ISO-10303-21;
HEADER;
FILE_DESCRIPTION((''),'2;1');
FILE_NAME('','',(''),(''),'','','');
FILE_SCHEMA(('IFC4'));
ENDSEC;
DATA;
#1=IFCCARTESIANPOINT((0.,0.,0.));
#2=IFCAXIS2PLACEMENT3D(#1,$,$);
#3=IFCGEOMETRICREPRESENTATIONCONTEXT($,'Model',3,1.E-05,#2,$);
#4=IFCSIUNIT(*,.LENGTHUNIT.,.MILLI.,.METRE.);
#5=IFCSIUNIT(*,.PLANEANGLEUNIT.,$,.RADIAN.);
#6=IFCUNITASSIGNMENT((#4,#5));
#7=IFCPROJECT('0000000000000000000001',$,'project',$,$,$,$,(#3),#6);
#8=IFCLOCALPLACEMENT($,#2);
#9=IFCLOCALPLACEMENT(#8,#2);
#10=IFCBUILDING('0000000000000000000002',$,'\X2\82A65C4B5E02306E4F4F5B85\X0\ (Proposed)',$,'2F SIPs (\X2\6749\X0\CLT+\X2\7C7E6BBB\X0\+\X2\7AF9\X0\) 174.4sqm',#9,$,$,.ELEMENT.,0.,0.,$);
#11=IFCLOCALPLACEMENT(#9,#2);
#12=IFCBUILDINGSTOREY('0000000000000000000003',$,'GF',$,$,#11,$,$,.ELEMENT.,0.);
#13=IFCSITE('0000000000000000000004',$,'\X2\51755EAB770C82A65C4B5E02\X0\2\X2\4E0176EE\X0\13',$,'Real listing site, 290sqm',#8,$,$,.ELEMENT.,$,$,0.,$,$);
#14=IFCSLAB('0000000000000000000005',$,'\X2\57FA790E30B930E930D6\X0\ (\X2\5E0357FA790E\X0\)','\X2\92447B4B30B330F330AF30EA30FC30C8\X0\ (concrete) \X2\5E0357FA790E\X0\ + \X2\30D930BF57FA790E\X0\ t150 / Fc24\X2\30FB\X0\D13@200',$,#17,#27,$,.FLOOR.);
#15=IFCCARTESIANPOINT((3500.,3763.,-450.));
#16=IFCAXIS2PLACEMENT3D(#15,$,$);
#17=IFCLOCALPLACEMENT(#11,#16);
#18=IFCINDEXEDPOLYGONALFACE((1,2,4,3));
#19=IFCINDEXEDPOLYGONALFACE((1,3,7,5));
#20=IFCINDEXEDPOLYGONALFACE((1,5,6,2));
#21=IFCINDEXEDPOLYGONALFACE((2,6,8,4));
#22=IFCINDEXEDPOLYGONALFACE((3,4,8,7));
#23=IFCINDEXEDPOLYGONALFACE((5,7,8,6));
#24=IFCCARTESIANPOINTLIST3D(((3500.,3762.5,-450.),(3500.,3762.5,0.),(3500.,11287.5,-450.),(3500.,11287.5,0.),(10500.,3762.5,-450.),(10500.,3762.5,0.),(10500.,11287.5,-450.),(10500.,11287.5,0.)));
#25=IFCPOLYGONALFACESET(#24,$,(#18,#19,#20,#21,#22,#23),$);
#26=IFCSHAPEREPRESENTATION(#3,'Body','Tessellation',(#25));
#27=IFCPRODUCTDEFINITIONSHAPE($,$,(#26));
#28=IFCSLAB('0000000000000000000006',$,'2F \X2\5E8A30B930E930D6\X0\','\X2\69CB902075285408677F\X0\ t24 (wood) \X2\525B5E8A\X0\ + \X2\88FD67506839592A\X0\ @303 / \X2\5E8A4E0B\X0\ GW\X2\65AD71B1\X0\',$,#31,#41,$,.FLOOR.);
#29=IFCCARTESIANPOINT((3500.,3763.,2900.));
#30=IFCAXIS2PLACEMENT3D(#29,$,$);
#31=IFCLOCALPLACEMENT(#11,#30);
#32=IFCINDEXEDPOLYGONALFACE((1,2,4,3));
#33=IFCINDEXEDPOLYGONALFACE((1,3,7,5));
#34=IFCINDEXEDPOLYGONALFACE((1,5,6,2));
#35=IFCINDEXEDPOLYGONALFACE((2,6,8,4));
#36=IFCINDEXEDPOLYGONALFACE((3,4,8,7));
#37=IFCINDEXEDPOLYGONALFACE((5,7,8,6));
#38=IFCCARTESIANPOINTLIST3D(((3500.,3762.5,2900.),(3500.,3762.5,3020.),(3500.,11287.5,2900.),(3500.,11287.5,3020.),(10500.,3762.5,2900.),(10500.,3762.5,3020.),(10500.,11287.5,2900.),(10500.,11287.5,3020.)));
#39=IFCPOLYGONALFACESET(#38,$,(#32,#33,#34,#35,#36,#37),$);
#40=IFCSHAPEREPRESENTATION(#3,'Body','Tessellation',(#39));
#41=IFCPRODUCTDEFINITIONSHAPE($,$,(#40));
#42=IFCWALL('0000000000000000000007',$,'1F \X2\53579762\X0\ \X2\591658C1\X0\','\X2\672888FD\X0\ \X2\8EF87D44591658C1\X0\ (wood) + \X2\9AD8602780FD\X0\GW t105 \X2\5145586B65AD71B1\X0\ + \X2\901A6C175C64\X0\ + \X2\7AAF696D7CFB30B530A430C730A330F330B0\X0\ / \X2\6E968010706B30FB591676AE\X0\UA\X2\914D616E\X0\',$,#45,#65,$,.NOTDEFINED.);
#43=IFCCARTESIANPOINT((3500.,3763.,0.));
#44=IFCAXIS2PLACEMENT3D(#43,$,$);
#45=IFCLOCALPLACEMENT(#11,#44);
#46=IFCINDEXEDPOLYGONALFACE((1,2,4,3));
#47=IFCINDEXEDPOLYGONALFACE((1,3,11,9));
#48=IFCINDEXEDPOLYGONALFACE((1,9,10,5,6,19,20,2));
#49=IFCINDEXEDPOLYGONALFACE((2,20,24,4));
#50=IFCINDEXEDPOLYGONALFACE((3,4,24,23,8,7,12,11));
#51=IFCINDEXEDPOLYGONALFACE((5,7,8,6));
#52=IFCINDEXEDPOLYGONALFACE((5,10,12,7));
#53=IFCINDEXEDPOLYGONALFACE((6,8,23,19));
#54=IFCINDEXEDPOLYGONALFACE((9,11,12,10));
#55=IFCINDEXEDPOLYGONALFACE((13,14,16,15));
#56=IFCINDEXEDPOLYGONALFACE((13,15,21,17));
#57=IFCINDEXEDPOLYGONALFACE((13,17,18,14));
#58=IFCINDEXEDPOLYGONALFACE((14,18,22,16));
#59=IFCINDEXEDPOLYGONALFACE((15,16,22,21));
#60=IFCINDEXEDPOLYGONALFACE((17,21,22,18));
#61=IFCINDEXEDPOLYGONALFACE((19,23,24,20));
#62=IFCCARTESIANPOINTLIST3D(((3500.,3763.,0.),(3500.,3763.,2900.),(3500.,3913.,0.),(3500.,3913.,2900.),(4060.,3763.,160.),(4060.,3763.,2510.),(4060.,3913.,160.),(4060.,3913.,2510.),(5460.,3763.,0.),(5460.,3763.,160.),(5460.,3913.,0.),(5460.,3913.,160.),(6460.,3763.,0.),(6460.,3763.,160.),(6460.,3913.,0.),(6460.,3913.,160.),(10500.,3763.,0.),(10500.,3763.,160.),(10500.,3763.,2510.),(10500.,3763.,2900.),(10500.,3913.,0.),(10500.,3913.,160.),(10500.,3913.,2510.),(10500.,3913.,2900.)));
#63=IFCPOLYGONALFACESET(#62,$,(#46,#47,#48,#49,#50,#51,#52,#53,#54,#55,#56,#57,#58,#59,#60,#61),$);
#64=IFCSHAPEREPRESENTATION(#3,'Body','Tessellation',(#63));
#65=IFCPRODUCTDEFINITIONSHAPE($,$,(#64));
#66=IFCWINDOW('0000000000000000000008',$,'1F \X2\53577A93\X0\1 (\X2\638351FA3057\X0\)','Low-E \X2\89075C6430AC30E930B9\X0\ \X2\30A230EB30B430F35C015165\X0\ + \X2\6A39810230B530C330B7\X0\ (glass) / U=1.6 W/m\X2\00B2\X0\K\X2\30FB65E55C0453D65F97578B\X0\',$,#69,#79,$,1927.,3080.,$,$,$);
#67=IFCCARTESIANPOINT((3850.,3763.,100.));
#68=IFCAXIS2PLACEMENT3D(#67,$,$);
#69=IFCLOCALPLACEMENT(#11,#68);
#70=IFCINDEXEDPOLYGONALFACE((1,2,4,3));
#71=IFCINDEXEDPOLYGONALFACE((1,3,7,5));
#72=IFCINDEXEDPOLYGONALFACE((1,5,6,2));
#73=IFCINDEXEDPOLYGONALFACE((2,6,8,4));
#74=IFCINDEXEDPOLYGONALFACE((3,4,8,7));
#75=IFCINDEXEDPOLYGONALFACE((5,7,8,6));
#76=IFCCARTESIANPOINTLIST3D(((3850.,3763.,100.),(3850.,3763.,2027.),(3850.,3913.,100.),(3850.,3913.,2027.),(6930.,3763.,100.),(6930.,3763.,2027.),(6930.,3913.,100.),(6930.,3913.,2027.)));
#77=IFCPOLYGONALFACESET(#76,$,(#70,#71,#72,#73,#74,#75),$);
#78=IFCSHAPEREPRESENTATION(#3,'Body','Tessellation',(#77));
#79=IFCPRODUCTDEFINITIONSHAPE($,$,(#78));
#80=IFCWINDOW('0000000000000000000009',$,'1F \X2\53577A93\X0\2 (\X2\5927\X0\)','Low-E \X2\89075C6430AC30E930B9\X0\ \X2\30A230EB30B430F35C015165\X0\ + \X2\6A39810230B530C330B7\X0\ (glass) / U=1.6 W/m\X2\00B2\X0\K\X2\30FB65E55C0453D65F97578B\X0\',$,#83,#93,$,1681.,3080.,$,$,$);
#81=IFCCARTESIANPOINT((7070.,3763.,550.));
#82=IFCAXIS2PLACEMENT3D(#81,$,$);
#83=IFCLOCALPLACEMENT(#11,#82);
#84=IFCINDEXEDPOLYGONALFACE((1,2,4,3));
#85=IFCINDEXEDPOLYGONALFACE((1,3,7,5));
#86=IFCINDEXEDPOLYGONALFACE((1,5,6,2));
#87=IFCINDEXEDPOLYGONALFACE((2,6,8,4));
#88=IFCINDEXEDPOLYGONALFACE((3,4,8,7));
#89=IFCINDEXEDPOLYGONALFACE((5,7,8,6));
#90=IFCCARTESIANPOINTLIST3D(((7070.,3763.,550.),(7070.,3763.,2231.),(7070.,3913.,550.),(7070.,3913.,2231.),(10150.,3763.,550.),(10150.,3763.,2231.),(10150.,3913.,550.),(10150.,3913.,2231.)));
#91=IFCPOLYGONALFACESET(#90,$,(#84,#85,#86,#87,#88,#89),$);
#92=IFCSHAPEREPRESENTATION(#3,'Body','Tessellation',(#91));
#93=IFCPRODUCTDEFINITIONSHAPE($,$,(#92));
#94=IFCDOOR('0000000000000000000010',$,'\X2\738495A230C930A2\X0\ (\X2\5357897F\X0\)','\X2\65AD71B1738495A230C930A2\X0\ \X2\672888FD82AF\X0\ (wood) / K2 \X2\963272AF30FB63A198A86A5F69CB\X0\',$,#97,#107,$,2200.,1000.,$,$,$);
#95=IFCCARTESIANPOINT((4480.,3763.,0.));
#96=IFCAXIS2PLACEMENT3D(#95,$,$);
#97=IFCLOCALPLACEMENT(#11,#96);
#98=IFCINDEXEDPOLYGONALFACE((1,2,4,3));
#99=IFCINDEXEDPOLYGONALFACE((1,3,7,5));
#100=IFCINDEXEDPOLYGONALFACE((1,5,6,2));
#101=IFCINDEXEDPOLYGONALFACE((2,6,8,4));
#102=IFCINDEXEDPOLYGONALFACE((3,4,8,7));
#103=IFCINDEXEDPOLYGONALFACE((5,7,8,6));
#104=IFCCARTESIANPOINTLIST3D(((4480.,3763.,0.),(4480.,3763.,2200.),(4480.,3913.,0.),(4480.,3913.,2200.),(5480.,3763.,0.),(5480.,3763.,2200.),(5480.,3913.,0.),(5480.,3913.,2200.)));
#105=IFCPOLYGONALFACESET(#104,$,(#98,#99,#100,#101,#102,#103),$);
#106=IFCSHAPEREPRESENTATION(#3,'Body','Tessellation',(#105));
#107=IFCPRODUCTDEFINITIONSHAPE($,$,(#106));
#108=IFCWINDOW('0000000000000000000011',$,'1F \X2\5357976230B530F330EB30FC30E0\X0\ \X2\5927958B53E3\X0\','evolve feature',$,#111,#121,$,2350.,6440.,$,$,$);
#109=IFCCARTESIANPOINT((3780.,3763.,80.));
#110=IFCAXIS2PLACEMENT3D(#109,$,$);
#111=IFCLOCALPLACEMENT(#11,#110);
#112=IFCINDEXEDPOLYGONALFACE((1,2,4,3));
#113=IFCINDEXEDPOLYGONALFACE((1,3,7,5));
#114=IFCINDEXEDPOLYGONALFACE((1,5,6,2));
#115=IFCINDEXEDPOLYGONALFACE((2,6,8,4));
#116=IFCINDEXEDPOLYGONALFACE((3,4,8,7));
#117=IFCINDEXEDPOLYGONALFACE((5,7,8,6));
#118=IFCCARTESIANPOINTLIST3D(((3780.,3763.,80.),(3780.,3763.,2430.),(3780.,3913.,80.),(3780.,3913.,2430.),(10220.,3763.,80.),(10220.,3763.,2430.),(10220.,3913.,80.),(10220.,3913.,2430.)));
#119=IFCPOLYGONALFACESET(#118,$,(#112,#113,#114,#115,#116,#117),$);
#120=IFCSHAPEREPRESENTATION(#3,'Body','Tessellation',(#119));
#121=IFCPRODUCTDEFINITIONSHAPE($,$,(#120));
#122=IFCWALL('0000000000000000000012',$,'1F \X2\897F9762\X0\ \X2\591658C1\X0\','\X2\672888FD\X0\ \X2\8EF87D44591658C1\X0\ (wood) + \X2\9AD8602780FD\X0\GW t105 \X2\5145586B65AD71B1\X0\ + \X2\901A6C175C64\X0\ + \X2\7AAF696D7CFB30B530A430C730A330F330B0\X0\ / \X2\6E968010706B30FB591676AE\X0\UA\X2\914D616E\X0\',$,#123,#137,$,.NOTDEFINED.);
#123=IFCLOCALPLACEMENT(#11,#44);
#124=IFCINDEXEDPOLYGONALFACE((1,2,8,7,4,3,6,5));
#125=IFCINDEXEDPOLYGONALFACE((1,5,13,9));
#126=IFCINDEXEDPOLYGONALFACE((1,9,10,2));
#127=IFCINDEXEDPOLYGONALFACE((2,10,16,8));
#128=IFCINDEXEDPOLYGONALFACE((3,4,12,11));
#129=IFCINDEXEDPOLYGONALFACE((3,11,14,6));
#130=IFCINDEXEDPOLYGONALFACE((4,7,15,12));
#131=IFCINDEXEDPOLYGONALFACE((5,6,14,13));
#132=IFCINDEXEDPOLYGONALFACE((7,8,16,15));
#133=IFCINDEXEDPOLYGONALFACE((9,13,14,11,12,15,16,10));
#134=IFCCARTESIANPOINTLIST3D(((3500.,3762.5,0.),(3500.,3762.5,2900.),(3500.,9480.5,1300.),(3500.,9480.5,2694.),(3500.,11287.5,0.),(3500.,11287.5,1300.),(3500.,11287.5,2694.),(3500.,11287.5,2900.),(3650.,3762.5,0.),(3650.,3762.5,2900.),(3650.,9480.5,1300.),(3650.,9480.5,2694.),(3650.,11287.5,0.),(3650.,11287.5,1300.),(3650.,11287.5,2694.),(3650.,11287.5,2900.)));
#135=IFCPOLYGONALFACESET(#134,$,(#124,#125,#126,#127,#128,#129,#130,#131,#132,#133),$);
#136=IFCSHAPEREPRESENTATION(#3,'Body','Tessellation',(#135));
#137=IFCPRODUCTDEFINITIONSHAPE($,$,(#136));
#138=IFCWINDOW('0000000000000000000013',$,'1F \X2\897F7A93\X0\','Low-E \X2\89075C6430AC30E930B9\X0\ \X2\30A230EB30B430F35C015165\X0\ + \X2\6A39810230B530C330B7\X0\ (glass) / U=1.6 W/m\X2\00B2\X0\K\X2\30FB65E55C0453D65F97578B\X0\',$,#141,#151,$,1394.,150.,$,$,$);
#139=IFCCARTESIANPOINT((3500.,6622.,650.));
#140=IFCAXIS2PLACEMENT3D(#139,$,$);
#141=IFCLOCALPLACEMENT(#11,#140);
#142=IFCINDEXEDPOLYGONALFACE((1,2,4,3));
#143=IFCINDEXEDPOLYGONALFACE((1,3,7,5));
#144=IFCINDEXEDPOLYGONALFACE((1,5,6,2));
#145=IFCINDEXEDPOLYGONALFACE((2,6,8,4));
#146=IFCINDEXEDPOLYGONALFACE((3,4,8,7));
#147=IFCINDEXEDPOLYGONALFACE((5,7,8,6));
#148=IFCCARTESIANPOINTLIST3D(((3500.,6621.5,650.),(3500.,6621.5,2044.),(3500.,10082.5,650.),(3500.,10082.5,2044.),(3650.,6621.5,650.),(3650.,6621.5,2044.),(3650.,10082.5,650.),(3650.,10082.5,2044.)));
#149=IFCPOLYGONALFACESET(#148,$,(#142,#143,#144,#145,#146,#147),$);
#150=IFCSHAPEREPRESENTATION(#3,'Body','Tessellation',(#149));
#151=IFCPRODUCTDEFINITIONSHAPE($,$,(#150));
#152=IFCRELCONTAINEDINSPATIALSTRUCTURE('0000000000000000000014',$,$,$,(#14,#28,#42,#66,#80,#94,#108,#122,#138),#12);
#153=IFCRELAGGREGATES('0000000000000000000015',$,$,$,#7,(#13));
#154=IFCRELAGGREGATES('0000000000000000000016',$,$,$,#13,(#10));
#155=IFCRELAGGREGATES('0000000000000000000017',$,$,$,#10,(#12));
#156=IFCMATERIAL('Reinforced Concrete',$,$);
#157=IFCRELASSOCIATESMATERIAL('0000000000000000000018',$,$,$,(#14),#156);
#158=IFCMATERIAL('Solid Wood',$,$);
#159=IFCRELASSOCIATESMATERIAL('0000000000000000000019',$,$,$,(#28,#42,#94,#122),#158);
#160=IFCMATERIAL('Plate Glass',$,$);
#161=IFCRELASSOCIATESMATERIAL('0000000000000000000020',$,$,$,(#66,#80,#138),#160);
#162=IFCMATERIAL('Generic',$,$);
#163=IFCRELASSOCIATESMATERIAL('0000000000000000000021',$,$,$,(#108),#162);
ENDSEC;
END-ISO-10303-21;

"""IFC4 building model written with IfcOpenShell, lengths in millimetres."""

from ifc_helpers import new_model, si_unit, frame, frame_2d, origin, place, context, project, spatial, rectangle, extrude, material, element, fill, save


model = new_model("IFC4")

# Units and contexts
model_context = context("Model", 3, precision=1e-05, world=origin())
ifc_project = project(units=[si_unit("LENGTHUNIT", "METRE", prefix="MILLI"), si_unit("PLANEANGLEUNIT", "RADIAN")], contexts=[model_context])

# Site, building, storey
site_placement = place(None, origin())
site = spatial("IfcSite", under=ifc_project, at=site_placement, Name="兵庫県芦屋市2丁目13", ObjectType="Real listing site, 290sqm", CompositionType="ELEMENT", RefElevation=0.0)
building_placement = place(site_placement, origin())
building = spatial("IfcBuilding", under=site, at=building_placement, Name="芦屋市の住宅 (Proposed)", ObjectType="2F SIPs (杉CLT+籾殻+竹) 174.4sqm", CompositionType="ELEMENT", ElevationOfRefHeight=0.0, ElevationOfTerrain=0.0)
storey_placement = place(building_placement, origin())
storey = spatial("IfcBuildingStorey", under=building, at=storey_placement, Name="GF", CompositionType="ELEMENT", Elevation=0.0)

# Slabs
ifc_material_1 = material(Name="Reinforced Concrete")
slab_1_placement = place(storey_placement, frame((3500.0, 3763.0, -450.0)))
element("IfcSlab", 1, at=slab_1_placement, inside=storey, material=ifc_material_1, Name="基礎スラブ (布基礎)", Description="鉄筋コンクリート (concrete) 布基礎 + ベタ基礎 t150 / Fc24・D13@200", PredefinedType="FLOOR", context=model_context, shape_type="SweptSolid", body=[
    extrude(rectangle(XDim=7000.0, YDim=7525.0, at=frame_2d((3500.0, 3762.0))), frame((3500.0, 3763.0, -450.0)), (0.0, 0.0, 1.0), 450.0),
])
ifc_material_2 = material(Name="Solid Wood")
slab_2_placement = place(storey_placement, frame((3500.0, 3763.0, 2900.0)))
element("IfcSlab", 2, at=slab_2_placement, inside=storey, material=ifc_material_2, Name="2F 床スラブ", Description="構造用合板 t24 (wood) 剛床 + 製材根太 @303 / 床下 GW断熱", PredefinedType="FLOOR", context=model_context, shape_type="SweptSolid", body=[
    extrude(rectangle(XDim=7000.0, YDim=7525.0, at=frame_2d((3500.0, 3762.0))), frame((3500.0, 3763.0, 2900.0)), (0.0, 0.0, 1.0), 120.0),
])
ifc_material_3 = material(Name="Generic")

# Wall, openings, windows, door
wall_1_placement = place(storey_placement, frame((3500.0, 3763.0, 0.0)))
wall_1 = element("IfcWall", 3, at=wall_1_placement, inside=storey, material=ifc_material_2, Name="1F 南面 外壁", Description="木製 軸組外壁 (wood) + 高性能GW t105 充填断熱 + 通気層 + 窯業系サイディング / 準耐火・外皮UA配慮", PredefinedType="NOTDEFINED", context=model_context, shape_type="SweptSolid", body=[
    extrude(rectangle(XDim=7000.0, YDim=150.0, at=frame_2d((3500.0, 75.0))), frame((3500.0, 3763.0, 0.0)), (0.0, 0.0, 1.0), 2900.0),
])
opening_1_placement = place(storey_placement, frame((3850.0, 3763.0, 100.0)))
opening_1 = element("IfcOpeningElement", 4, at=opening_1_placement, cuts=wall_1, PredefinedType="NOTDEFINED", context=model_context, shape_type="SweptSolid", body=[
    extrude(rectangle(XDim=3080.0, YDim=150.0, at=frame_2d((1540.0, 75.0))), frame((3850.0, 3763.0, 100.0)), (0.0, 0.0, 1.0), 1927.0),
])
opening_2_placement = place(storey_placement, frame((7070.0, 3763.0, 550.0)))
opening_2 = element("IfcOpeningElement", 5, at=opening_2_placement, cuts=wall_1, PredefinedType="NOTDEFINED", context=model_context, shape_type="SweptSolid", body=[
    extrude(rectangle(XDim=3080.0, YDim=150.0, at=frame_2d((1540.0, 75.0))), frame((7070.0, 3763.0, 550.0)), (0.0, 0.0, 1.0), 1681.0),
])
opening_3_placement = place(storey_placement, frame((4480.0, 3763.0, 0.0)))
opening_3 = element("IfcOpeningElement", 6, at=opening_3_placement, cuts=wall_1, PredefinedType="NOTDEFINED", context=model_context, shape_type="SweptSolid", body=[
    extrude(rectangle(XDim=1000.0, YDim=150.0, at=frame_2d((500.0, 75.0))), frame((4480.0, 3763.0, 0.0)), (0.0, 0.0, 1.0), 2200.0),
])
opening_4_placement = place(storey_placement, frame((3780.0, 3763.0, 80.0)))
opening_4 = element("IfcOpeningElement", 7, at=opening_4_placement, cuts=wall_1, PredefinedType="NOTDEFINED", context=model_context, shape_type="SweptSolid", body=[
    extrude(rectangle(XDim=6440.0, YDim=150.0, at=frame_2d((3220.0, 75.0))), frame((3780.0, 3763.0, 80.0)), (0.0, 0.0, 1.0), 2350.0),
])
ifc_material_4 = material(Name="Plate Glass")
window_1_placement = place(storey_placement, frame((3850.0, 3763.0, 100.0)))
window_1 = element("IfcWindow", 8, at=window_1_placement, inside=storey, material=ifc_material_4, Name="1F 南窓1 (掃出し)", Description="Low-E 複層ガラス アルゴン封入 + 樹脂サッシ (glass) / U=1.6 W/m²K・日射取得型", OverallHeight=1927.0, OverallWidth=3080.0, context=model_context, shape_type="SweptSolid", body=[
    extrude(rectangle(XDim=3080.0, YDim=150.0, at=frame_2d((1540.0, 75.0))), frame((3850.0, 3763.0, 100.0)), (0.0, 0.0, 1.0), 1927.0),
])
fill(opening_1, window_1)
window_2_placement = place(storey_placement, frame((7070.0, 3763.0, 550.0)))
window_2 = element("IfcWindow", 9, at=window_2_placement, inside=storey, material=ifc_material_4, Name="1F 南窓2 (大)", Description="Low-E 複層ガラス アルゴン封入 + 樹脂サッシ (glass) / U=1.6 W/m²K・日射取得型", OverallHeight=1681.0, OverallWidth=3080.0, context=model_context, shape_type="SweptSolid", body=[
    extrude(rectangle(XDim=3080.0, YDim=150.0, at=frame_2d((1540.0, 75.0))), frame((7070.0, 3763.0, 550.0)), (0.0, 0.0, 1.0), 1681.0),
])
fill(opening_2, window_2)
door_placement = place(storey_placement, frame((4480.0, 3763.0, 0.0)))
door = element("IfcDoor", 10, at=door_placement, inside=storey, material=ifc_material_2, Name="玄関ドア (南西)", Description="断熱玄関ドア 木製芯 (wood) / K2 防犯・採風機構", OverallHeight=2200.0, OverallWidth=1000.0, context=model_context, shape_type="SweptSolid", body=[
    extrude(rectangle(XDim=1000.0, YDim=150.0, at=frame_2d((500.0, 75.0))), frame((4480.0, 3763.0, 0.0)), (0.0, 0.0, 1.0), 2200.0),
])
fill(opening_3, door)
window_3_placement = place(storey_placement, frame((3780.0, 3763.0, 80.0)))
window_3 = element("IfcWindow", 11, at=window_3_placement, inside=storey, material=ifc_material_3, Name="1F 南面サンルーム 大開口", Description="evolve feature", OverallHeight=2350.0, OverallWidth=6440.0, context=model_context, shape_type="SweptSolid", body=[
    extrude(rectangle(XDim=6440.0, YDim=150.0, at=frame_2d((3220.0, 75.0))), frame((3780.0, 3763.0, 80.0)), (0.0, 0.0, 1.0), 2350.0),
])
fill(opening_4, window_3)

# Wall, opening, window
wall_2_placement = place(storey_placement, frame((3500.0, 3763.0, 0.0)))
wall_2 = element("IfcWall", 12, at=wall_2_placement, inside=storey, material=ifc_material_2, Name="1F 西面 外壁", Description="木製 軸組外壁 (wood) + 高性能GW t105 充填断熱 + 通気層 + 窯業系サイディング / 準耐火・外皮UA配慮", PredefinedType="NOTDEFINED", context=model_context, shape_type="SweptSolid", body=[
    extrude(rectangle(XDim=150.0, YDim=7525.0, at=frame_2d((75.0, 3762.0))), frame((3500.0, 3763.0, 0.0)), (0.0, 0.0, 1.0), 2900.0),
])
opening_5_placement = place(storey_placement, frame((3500.0, 6622.0, 650.0)))
opening_5 = element("IfcOpeningElement", 13, at=opening_5_placement, cuts=wall_2, PredefinedType="NOTDEFINED", context=model_context, shape_type="SweptSolid", body=[
    extrude(rectangle(XDim=150.0, YDim=3461.0, at=frame_2d((75.0, 1730.0))), frame((3500.0, 6622.0, 650.0)), (0.0, 0.0, 1.0), 1394.0),
])
window_4_placement = place(storey_placement, frame((3500.0, 6622.0, 650.0)))
window_4 = element("IfcWindow", 14, at=window_4_placement, inside=storey, material=ifc_material_4, Name="1F 西窓", Description="Low-E 複層ガラス アルゴン封入 + 樹脂サッシ (glass) / U=1.6 W/m²K・日射取得型", OverallHeight=1394.0, OverallWidth=150.0, context=model_context, shape_type="SweptSolid", body=[
    extrude(rectangle(XDim=150.0, YDim=3461.0, at=frame_2d((75.0, 1730.0))), frame((3500.0, 6622.0, 650.0)), (0.0, 0.0, 1.0), 1394.0),
])
fill(opening_5, window_4)

save(model, "model.ifc")
